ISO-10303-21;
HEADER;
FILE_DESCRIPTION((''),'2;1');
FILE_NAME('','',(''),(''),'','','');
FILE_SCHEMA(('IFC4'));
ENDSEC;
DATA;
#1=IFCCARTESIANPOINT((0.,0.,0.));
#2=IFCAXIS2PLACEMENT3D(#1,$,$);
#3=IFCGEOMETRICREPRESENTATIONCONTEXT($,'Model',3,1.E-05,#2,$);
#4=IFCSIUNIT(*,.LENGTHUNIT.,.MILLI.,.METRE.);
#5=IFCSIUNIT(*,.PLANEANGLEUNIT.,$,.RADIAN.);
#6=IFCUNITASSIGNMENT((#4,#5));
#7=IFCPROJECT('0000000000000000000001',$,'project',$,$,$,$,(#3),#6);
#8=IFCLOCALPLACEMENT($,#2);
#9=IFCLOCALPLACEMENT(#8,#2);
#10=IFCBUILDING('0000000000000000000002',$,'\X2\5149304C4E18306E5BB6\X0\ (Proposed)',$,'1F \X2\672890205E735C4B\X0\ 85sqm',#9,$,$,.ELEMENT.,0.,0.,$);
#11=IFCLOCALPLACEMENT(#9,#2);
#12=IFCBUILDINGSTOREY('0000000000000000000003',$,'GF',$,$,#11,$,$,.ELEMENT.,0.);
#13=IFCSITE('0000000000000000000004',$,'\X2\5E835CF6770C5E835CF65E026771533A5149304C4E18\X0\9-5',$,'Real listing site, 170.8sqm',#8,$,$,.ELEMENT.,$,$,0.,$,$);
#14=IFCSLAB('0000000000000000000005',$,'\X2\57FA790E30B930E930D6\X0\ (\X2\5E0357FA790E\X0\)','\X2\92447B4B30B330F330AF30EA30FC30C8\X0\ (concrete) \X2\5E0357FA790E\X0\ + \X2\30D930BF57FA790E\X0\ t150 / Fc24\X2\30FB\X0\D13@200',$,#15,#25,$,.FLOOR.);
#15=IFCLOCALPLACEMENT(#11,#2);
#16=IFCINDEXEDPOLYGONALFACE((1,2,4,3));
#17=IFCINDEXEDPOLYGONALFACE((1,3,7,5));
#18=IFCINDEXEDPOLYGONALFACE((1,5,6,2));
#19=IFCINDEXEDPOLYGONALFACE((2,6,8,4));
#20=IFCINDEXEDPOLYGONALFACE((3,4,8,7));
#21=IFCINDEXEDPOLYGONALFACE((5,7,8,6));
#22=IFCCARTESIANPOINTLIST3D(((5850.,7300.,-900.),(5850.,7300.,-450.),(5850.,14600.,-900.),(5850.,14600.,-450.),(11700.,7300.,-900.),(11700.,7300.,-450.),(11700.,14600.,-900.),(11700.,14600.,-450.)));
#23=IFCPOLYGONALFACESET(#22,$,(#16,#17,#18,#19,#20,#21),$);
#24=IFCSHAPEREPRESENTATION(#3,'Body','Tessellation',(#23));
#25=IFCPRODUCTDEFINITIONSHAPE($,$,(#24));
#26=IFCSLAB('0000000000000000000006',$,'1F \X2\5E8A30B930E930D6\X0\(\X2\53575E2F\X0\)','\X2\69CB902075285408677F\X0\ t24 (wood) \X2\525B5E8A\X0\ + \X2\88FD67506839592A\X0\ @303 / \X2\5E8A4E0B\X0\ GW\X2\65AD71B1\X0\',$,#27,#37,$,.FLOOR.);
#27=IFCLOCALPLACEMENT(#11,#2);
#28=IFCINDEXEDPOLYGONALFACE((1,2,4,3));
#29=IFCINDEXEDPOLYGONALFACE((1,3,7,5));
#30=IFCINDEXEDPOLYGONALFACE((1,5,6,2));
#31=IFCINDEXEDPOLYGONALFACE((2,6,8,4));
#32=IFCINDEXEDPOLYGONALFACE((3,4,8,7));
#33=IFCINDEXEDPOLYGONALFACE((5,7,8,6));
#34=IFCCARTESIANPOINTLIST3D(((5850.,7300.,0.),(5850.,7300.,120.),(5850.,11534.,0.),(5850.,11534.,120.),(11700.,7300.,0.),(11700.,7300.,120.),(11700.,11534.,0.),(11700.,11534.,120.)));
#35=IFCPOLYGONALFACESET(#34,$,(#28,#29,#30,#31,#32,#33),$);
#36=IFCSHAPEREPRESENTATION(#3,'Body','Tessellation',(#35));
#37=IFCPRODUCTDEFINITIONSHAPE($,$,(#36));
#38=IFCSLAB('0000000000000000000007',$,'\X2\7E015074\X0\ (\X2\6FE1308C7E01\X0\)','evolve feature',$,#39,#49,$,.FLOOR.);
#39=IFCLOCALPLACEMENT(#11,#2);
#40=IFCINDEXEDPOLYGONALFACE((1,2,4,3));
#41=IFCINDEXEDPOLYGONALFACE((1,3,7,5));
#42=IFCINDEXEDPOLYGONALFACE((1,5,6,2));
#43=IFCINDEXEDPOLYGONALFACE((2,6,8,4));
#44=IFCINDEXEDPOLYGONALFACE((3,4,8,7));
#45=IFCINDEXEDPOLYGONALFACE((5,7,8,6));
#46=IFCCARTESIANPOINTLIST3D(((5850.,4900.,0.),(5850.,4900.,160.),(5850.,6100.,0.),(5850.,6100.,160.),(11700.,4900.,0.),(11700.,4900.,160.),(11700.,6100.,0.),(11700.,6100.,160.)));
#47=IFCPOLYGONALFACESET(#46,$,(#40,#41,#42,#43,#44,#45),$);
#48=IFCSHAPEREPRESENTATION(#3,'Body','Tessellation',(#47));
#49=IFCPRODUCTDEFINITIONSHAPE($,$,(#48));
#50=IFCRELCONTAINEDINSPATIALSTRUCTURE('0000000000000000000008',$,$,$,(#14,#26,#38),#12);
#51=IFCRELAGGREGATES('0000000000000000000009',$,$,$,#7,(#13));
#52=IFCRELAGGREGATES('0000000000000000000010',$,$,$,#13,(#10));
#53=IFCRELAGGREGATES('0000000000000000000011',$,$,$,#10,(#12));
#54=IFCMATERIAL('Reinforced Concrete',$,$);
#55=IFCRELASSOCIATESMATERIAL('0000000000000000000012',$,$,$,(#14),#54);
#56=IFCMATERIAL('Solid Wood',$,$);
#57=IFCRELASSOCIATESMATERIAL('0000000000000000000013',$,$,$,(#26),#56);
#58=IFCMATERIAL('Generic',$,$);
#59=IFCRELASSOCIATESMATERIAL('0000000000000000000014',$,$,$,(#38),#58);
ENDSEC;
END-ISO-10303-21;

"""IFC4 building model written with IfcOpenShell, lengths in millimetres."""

from ifc_helpers import new_model, si_unit, frame, frame_2d, origin, place, context, project, spatial, rectangle, extrude, material, element, save


model = new_model("IFC4")

# Units and contexts
model_context = context("Model", 3, precision=1e-05, world=origin())
ifc_project = project(units=[si_unit("LENGTHUNIT", "METRE", prefix="MILLI"), si_unit("PLANEANGLEUNIT", "RADIAN")], contexts=[model_context])

# Site, building, storey
site_placement = place(None, origin())
site = spatial("IfcSite", under=ifc_project, at=site_placement, Name="広島県広島市東区光が丘9-5", ObjectType="Real listing site, 170.8sqm", CompositionType="ELEMENT", RefElevation=0.0)
building_placement = place(site_placement, origin())
building = spatial("IfcBuilding", under=site, at=building_placement, Name="光が丘の家 (Proposed)", ObjectType="1F 木造平屋 85sqm", CompositionType="ELEMENT", ElevationOfRefHeight=0.0, ElevationOfTerrain=0.0)
storey_placement = place(building_placement, origin())
storey = spatial("IfcBuildingStorey", under=building, at=storey_placement, Name="GF", CompositionType="ELEMENT", Elevation=0.0)

# Slabs
ifc_material_1 = material(Name="Reinforced Concrete")
slab_1_placement = place(storey_placement, frame((2925.0, 3650.0, -450.0)))
element("IfcSlab", 1, at=slab_1_placement, inside=storey, material=ifc_material_1, Name="基礎スラブ (布基礎)", Description="鉄筋コンクリート (concrete) 布基礎 + ベタ基礎 t150 / Fc24・D13@200", PredefinedType="FLOOR", context=model_context, shape_type="SweptSolid", body=[
    extrude(rectangle(XDim=5850.0, YDim=7300.0, at=frame_2d((2925.0, 3650.0))), frame((2925.0, 3650.0, -450.0)), (0.0, 0.0, 1.0), 450.0),
])
ifc_material_2 = material(Name="Solid Wood")
slab_2_placement = place(storey_placement, frame((2925.0, 3650.0, 0.0)))
element("IfcSlab", 2, at=slab_2_placement, inside=storey, material=ifc_material_2, Name="1F 床スラブ(南帯)", Description="構造用合板 t24 (wood) 剛床 + 製材根太 @303 / 床下 GW断熱", PredefinedType="FLOOR", context=model_context, shape_type="SweptSolid", body=[
    extrude(rectangle(XDim=5850.0, YDim=4234.0, at=frame_2d((2925.0, 2117.0))), frame((2925.0, 3650.0, 0.0)), (0.0, 0.0, 1.0), 120.0),
])
ifc_material_3 = material(Name="Generic")
slab_3_placement = place(storey_placement, frame((2925.0, 2450.0, 0.0)))
element("IfcSlab", 3, at=slab_3_placement, inside=storey, material=ifc_material_3, Name="縁側 (濡れ縁)", Description="evolve feature", PredefinedType="FLOOR", context=model_context, shape_type="SweptSolid", body=[
    extrude(rectangle(XDim=5850.0, YDim=1200.0, at=frame_2d((2925.0, 600.0))), frame((2925.0, 2450.0, 0.0)), (0.0, 0.0, 1.0), 160.0),
])

save(model, "model.ifc")
